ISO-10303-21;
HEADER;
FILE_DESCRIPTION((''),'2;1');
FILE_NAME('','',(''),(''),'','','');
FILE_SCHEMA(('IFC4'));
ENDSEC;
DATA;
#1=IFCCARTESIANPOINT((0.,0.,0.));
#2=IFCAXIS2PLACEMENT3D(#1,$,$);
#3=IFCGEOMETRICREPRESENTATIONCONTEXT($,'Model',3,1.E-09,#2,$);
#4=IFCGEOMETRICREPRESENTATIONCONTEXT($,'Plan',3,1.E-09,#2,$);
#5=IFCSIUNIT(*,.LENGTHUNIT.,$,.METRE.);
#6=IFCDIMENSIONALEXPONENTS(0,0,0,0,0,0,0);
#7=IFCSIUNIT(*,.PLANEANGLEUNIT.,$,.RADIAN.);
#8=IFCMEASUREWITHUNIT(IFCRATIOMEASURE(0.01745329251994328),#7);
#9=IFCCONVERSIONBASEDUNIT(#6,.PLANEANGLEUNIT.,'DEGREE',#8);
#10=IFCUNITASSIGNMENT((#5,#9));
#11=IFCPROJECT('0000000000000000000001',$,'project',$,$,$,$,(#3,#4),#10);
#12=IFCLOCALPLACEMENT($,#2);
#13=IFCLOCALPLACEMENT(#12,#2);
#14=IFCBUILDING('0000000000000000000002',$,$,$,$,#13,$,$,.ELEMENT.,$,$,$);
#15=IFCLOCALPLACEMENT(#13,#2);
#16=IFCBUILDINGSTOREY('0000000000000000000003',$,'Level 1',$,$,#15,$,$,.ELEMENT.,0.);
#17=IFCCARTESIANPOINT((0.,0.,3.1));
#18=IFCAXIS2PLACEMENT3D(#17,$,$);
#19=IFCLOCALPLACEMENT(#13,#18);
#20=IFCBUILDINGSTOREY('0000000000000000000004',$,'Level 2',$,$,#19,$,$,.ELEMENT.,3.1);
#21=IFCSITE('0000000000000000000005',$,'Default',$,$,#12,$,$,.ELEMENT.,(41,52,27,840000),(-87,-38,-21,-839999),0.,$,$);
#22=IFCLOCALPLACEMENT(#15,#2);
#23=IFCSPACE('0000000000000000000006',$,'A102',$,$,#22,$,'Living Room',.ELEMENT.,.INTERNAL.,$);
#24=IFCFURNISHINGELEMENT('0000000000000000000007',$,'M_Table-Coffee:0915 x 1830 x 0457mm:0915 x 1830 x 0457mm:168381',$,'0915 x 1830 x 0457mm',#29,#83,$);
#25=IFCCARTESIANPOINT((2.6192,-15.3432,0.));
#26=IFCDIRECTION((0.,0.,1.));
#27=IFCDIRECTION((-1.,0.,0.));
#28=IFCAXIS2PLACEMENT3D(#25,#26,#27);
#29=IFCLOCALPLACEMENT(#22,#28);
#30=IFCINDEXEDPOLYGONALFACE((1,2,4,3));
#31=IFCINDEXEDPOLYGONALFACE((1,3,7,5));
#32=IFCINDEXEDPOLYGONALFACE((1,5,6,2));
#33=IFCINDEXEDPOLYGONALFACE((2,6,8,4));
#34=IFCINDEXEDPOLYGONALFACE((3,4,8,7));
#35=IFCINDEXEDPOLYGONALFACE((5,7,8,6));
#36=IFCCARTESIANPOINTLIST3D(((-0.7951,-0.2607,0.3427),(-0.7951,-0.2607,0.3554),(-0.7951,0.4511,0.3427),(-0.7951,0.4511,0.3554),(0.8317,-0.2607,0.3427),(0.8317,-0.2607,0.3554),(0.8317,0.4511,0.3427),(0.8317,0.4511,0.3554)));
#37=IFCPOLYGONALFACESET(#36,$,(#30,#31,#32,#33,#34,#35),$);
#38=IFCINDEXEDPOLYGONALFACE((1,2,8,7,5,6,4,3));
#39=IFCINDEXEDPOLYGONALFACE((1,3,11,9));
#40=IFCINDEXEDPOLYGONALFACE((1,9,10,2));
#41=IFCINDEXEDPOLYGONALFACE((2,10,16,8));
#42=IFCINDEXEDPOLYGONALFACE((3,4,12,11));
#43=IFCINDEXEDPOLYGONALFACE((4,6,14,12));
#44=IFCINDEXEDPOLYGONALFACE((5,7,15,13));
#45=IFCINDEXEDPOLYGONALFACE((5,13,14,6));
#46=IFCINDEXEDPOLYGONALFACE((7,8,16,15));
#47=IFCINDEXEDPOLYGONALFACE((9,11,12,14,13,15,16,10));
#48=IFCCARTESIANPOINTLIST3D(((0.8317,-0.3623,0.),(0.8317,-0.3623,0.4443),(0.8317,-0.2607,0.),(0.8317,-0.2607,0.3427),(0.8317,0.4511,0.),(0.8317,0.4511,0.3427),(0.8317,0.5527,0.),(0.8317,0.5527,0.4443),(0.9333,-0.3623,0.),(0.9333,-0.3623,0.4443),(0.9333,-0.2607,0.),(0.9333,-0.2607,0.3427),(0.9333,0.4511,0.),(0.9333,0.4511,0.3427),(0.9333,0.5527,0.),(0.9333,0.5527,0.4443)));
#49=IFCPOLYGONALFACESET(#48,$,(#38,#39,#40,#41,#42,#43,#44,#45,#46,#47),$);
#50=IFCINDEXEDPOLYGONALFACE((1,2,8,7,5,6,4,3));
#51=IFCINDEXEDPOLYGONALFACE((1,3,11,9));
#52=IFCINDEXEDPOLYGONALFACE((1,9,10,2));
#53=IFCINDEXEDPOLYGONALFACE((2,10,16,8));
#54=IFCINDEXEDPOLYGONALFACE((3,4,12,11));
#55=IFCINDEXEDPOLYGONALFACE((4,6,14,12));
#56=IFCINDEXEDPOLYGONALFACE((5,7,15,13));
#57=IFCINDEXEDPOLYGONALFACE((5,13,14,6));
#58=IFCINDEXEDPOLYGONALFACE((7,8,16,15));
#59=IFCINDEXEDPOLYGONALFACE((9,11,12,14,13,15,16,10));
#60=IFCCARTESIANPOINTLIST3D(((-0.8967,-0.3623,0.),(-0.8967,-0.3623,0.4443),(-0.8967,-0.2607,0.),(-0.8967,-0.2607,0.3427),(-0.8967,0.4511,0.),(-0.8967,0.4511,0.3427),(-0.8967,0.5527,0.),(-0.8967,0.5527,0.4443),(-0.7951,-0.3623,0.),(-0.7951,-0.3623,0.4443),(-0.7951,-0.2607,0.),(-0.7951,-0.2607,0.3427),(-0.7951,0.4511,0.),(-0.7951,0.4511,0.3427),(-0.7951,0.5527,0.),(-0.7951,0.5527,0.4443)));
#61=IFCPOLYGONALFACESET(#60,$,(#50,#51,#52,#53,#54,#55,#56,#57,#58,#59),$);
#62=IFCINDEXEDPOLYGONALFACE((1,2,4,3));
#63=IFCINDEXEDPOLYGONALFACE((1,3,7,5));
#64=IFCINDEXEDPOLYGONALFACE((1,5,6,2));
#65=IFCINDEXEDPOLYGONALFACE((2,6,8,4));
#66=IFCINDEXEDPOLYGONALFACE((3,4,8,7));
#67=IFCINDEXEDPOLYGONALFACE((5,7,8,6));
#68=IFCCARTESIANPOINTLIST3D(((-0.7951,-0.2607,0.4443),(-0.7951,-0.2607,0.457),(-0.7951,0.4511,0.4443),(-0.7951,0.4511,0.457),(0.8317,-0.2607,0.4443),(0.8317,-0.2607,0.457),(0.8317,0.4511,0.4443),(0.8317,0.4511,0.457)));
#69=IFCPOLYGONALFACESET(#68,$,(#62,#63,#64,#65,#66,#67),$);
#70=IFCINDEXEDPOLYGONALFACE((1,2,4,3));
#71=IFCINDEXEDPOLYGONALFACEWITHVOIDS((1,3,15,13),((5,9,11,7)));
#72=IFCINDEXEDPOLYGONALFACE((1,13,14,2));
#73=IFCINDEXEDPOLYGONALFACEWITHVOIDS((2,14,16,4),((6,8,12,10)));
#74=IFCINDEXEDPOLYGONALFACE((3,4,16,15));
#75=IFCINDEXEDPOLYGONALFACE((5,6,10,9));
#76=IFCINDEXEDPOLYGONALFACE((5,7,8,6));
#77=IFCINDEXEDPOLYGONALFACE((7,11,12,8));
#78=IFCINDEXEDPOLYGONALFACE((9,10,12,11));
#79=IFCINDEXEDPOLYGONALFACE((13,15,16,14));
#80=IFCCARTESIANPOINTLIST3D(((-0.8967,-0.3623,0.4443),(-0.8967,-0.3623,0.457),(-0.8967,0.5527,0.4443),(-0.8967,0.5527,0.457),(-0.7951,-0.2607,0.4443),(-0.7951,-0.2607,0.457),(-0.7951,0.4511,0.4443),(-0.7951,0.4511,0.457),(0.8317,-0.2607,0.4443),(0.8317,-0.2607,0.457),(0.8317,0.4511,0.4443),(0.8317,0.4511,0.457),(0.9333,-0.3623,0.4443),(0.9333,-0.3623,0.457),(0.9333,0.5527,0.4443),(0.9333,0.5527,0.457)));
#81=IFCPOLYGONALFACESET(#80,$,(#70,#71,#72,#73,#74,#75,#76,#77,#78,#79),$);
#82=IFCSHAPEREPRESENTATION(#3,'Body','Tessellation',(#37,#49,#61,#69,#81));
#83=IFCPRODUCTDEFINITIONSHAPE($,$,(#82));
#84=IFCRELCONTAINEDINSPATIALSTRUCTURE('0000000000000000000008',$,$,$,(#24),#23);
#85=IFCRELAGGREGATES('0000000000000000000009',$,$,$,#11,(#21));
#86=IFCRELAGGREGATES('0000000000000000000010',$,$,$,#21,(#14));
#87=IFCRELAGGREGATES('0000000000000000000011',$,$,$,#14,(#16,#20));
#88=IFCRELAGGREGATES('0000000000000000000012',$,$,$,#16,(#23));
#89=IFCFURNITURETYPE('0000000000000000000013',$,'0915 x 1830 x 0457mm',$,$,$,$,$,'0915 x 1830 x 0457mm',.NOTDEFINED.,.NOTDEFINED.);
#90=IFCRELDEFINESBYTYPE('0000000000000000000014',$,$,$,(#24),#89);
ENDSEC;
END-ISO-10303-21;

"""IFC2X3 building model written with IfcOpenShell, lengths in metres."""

from ifc_helpers import new_model, entity, si_unit, converted_unit, frame, origin, origin_2d_with_axis, place, context, project, spatial, polyline, rectangle, outline, extrude, source, transform, mapped, type_object, type_shapes, element, save


model = new_model("IFC2X3")

# Units and contexts
model_context = context("Model", 3, precision=1e-09, world=origin())
plan_context = context("Plan", 3, precision=1e-09, world=origin())
ifc_project = project(units=[si_unit("LENGTHUNIT", "METRE"), converted_unit("PLANEANGLEUNIT", "DEGREE", entity("IfcRatioMeasure", 0.01745329251994328), si_unit("PLANEANGLEUNIT", "RADIAN"), dimensions=[0, 0, 0, 0, 0, 0, 0])], contexts=[model_context, plan_context])

# Site, building, storey
site_placement = place(None, origin())
site = spatial("IfcSite", under=ifc_project, at=site_placement, Name="Default", CompositionType="ELEMENT", RefLatitude=(41, 52, 27, 840000), RefLongitude=(-87, -38, -21, -839999), RefElevation=0.0)
building_placement = place(site_placement, origin())
building = spatial("IfcBuilding", under=site, at=building_placement, CompositionType="ELEMENT")
storey_1_placement = place(building_placement, origin())
storey_1 = spatial("IfcBuildingStorey", under=building, at=storey_1_placement, Name="Level 1", CompositionType="ELEMENT", Elevation=0.0)

# Shared definitions
storey_2_placement = place(building_placement, frame((0.0, 0.0, 3.1)))
storey_2 = spatial("IfcBuildingStorey", under=building, at=storey_2_placement, Name="Level 2", CompositionType="ELEMENT", Elevation=3.1)

# Shared definitions
space_1_placement = place(storey_1_placement, origin())
space_1 = spatial("IfcSpace", under=storey_1, at=space_1_placement, Name="A102", LongName="Living Room", CompositionType="ELEMENT", InteriorOrExteriorSpace="INTERNAL")

# Furnishing element
furniture_type_1 = type_object("IfcFurnitureType", Name="0915 x 1830 x 0457mm", ElementType="0915 x 1830 x 0457mm", AssemblyPlace="NOTDEFINED")
shared_shape_1 = source(origin(), model_context, "Body", "SweptSolid", [
    extrude(rectangle(XDim=1.6268, YDim=0.7118, at=origin_2d_with_axis()), frame((0.0183, 0.0952, 0.3427), z_axis=(0.0, 0.0, 1.0), x_axis=(-1.0, 0.0, 0.0)), (0.0, 0.0, 1.0), 0.0127),
    extrude(outline(polyline([(-0.1967, -0.4575), (0.2475, -0.4575), (0.2475, 0.4575), (-0.1967, 0.4575), (-0.1967, 0.3559), (0.146, 0.3559), (0.146, -0.3559), (-0.1967, -0.3559), (-0.1967, -0.4575)])), frame((0.8317, 0.0952, 0.1967), z_axis=(1.0, 0.0, 0.0), x_axis=(0.0, 0.0, 1.0)), (0.0, 0.0, 1.0), 0.1016),
    extrude(outline(polyline([(-0.4575, -0.2476), (0.4575, -0.2476), (0.4575, 0.1968), (0.3559, 0.1968), (0.3559, -0.1459), (-0.3559, -0.1459), (-0.3559, 0.1968), (-0.4575, 0.1968), (-0.4575, -0.2476)])), frame((-0.8967, 0.0952, 0.1968), z_axis=(1.0, 0.0, 0.0), x_axis=(0.0, -1.0, 0.0)), (0.0, 0.0, 1.0), 0.1016),
    extrude(rectangle(XDim=1.6268, YDim=0.7118, at=origin_2d_with_axis()), frame((0.0183, 0.0952, 0.4443), z_axis=(0.0, 0.0, 1.0), x_axis=(-1.0, 0.0, 0.0)), (0.0, 0.0, 1.0), 0.0127),
    extrude(outline(polyline([(-0.915, -0.4575), (0.915, -0.4575), (0.915, 0.4575), (-0.915, 0.4575), (-0.915, -0.4575)]), holes=[polyline([(-0.8134, -0.3559), (-0.8134, 0.3559), (0.8134, 0.3559), (0.8134, -0.3559), (-0.8134, -0.3559)])]), frame((0.0183, 0.0952, 0.4443), z_axis=(0.0, 0.0, 1.0), x_axis=(-1.0, 0.0, 0.0)), (0.0, 0.0, 1.0), 0.0127),
])
type_shapes(furniture_type_1, [shared_shape_1])
furnishing_1_placement = place(space_1_placement, frame((2.6192, -15.3432, 0.0), z_axis=(0.0, 0.0, 1.0), x_axis=(-1.0, 0.0, 0.0)))
element("IfcFurnishingElement", 1, at=furnishing_1_placement, inside=space_1, type_object=furniture_type_1, Name="M_Table-Coffee:0915 x 1830 x 0457mm:0915 x 1830 x 0457mm:168381", ObjectType="0915 x 1830 x 0457mm", context=model_context, shape_type="MappedRepresentation", body=[
    mapped(shared_shape_1, transform((0.0, 0.0, 0.0), scale=1.0)),
])

save(model, "model.ifc")
